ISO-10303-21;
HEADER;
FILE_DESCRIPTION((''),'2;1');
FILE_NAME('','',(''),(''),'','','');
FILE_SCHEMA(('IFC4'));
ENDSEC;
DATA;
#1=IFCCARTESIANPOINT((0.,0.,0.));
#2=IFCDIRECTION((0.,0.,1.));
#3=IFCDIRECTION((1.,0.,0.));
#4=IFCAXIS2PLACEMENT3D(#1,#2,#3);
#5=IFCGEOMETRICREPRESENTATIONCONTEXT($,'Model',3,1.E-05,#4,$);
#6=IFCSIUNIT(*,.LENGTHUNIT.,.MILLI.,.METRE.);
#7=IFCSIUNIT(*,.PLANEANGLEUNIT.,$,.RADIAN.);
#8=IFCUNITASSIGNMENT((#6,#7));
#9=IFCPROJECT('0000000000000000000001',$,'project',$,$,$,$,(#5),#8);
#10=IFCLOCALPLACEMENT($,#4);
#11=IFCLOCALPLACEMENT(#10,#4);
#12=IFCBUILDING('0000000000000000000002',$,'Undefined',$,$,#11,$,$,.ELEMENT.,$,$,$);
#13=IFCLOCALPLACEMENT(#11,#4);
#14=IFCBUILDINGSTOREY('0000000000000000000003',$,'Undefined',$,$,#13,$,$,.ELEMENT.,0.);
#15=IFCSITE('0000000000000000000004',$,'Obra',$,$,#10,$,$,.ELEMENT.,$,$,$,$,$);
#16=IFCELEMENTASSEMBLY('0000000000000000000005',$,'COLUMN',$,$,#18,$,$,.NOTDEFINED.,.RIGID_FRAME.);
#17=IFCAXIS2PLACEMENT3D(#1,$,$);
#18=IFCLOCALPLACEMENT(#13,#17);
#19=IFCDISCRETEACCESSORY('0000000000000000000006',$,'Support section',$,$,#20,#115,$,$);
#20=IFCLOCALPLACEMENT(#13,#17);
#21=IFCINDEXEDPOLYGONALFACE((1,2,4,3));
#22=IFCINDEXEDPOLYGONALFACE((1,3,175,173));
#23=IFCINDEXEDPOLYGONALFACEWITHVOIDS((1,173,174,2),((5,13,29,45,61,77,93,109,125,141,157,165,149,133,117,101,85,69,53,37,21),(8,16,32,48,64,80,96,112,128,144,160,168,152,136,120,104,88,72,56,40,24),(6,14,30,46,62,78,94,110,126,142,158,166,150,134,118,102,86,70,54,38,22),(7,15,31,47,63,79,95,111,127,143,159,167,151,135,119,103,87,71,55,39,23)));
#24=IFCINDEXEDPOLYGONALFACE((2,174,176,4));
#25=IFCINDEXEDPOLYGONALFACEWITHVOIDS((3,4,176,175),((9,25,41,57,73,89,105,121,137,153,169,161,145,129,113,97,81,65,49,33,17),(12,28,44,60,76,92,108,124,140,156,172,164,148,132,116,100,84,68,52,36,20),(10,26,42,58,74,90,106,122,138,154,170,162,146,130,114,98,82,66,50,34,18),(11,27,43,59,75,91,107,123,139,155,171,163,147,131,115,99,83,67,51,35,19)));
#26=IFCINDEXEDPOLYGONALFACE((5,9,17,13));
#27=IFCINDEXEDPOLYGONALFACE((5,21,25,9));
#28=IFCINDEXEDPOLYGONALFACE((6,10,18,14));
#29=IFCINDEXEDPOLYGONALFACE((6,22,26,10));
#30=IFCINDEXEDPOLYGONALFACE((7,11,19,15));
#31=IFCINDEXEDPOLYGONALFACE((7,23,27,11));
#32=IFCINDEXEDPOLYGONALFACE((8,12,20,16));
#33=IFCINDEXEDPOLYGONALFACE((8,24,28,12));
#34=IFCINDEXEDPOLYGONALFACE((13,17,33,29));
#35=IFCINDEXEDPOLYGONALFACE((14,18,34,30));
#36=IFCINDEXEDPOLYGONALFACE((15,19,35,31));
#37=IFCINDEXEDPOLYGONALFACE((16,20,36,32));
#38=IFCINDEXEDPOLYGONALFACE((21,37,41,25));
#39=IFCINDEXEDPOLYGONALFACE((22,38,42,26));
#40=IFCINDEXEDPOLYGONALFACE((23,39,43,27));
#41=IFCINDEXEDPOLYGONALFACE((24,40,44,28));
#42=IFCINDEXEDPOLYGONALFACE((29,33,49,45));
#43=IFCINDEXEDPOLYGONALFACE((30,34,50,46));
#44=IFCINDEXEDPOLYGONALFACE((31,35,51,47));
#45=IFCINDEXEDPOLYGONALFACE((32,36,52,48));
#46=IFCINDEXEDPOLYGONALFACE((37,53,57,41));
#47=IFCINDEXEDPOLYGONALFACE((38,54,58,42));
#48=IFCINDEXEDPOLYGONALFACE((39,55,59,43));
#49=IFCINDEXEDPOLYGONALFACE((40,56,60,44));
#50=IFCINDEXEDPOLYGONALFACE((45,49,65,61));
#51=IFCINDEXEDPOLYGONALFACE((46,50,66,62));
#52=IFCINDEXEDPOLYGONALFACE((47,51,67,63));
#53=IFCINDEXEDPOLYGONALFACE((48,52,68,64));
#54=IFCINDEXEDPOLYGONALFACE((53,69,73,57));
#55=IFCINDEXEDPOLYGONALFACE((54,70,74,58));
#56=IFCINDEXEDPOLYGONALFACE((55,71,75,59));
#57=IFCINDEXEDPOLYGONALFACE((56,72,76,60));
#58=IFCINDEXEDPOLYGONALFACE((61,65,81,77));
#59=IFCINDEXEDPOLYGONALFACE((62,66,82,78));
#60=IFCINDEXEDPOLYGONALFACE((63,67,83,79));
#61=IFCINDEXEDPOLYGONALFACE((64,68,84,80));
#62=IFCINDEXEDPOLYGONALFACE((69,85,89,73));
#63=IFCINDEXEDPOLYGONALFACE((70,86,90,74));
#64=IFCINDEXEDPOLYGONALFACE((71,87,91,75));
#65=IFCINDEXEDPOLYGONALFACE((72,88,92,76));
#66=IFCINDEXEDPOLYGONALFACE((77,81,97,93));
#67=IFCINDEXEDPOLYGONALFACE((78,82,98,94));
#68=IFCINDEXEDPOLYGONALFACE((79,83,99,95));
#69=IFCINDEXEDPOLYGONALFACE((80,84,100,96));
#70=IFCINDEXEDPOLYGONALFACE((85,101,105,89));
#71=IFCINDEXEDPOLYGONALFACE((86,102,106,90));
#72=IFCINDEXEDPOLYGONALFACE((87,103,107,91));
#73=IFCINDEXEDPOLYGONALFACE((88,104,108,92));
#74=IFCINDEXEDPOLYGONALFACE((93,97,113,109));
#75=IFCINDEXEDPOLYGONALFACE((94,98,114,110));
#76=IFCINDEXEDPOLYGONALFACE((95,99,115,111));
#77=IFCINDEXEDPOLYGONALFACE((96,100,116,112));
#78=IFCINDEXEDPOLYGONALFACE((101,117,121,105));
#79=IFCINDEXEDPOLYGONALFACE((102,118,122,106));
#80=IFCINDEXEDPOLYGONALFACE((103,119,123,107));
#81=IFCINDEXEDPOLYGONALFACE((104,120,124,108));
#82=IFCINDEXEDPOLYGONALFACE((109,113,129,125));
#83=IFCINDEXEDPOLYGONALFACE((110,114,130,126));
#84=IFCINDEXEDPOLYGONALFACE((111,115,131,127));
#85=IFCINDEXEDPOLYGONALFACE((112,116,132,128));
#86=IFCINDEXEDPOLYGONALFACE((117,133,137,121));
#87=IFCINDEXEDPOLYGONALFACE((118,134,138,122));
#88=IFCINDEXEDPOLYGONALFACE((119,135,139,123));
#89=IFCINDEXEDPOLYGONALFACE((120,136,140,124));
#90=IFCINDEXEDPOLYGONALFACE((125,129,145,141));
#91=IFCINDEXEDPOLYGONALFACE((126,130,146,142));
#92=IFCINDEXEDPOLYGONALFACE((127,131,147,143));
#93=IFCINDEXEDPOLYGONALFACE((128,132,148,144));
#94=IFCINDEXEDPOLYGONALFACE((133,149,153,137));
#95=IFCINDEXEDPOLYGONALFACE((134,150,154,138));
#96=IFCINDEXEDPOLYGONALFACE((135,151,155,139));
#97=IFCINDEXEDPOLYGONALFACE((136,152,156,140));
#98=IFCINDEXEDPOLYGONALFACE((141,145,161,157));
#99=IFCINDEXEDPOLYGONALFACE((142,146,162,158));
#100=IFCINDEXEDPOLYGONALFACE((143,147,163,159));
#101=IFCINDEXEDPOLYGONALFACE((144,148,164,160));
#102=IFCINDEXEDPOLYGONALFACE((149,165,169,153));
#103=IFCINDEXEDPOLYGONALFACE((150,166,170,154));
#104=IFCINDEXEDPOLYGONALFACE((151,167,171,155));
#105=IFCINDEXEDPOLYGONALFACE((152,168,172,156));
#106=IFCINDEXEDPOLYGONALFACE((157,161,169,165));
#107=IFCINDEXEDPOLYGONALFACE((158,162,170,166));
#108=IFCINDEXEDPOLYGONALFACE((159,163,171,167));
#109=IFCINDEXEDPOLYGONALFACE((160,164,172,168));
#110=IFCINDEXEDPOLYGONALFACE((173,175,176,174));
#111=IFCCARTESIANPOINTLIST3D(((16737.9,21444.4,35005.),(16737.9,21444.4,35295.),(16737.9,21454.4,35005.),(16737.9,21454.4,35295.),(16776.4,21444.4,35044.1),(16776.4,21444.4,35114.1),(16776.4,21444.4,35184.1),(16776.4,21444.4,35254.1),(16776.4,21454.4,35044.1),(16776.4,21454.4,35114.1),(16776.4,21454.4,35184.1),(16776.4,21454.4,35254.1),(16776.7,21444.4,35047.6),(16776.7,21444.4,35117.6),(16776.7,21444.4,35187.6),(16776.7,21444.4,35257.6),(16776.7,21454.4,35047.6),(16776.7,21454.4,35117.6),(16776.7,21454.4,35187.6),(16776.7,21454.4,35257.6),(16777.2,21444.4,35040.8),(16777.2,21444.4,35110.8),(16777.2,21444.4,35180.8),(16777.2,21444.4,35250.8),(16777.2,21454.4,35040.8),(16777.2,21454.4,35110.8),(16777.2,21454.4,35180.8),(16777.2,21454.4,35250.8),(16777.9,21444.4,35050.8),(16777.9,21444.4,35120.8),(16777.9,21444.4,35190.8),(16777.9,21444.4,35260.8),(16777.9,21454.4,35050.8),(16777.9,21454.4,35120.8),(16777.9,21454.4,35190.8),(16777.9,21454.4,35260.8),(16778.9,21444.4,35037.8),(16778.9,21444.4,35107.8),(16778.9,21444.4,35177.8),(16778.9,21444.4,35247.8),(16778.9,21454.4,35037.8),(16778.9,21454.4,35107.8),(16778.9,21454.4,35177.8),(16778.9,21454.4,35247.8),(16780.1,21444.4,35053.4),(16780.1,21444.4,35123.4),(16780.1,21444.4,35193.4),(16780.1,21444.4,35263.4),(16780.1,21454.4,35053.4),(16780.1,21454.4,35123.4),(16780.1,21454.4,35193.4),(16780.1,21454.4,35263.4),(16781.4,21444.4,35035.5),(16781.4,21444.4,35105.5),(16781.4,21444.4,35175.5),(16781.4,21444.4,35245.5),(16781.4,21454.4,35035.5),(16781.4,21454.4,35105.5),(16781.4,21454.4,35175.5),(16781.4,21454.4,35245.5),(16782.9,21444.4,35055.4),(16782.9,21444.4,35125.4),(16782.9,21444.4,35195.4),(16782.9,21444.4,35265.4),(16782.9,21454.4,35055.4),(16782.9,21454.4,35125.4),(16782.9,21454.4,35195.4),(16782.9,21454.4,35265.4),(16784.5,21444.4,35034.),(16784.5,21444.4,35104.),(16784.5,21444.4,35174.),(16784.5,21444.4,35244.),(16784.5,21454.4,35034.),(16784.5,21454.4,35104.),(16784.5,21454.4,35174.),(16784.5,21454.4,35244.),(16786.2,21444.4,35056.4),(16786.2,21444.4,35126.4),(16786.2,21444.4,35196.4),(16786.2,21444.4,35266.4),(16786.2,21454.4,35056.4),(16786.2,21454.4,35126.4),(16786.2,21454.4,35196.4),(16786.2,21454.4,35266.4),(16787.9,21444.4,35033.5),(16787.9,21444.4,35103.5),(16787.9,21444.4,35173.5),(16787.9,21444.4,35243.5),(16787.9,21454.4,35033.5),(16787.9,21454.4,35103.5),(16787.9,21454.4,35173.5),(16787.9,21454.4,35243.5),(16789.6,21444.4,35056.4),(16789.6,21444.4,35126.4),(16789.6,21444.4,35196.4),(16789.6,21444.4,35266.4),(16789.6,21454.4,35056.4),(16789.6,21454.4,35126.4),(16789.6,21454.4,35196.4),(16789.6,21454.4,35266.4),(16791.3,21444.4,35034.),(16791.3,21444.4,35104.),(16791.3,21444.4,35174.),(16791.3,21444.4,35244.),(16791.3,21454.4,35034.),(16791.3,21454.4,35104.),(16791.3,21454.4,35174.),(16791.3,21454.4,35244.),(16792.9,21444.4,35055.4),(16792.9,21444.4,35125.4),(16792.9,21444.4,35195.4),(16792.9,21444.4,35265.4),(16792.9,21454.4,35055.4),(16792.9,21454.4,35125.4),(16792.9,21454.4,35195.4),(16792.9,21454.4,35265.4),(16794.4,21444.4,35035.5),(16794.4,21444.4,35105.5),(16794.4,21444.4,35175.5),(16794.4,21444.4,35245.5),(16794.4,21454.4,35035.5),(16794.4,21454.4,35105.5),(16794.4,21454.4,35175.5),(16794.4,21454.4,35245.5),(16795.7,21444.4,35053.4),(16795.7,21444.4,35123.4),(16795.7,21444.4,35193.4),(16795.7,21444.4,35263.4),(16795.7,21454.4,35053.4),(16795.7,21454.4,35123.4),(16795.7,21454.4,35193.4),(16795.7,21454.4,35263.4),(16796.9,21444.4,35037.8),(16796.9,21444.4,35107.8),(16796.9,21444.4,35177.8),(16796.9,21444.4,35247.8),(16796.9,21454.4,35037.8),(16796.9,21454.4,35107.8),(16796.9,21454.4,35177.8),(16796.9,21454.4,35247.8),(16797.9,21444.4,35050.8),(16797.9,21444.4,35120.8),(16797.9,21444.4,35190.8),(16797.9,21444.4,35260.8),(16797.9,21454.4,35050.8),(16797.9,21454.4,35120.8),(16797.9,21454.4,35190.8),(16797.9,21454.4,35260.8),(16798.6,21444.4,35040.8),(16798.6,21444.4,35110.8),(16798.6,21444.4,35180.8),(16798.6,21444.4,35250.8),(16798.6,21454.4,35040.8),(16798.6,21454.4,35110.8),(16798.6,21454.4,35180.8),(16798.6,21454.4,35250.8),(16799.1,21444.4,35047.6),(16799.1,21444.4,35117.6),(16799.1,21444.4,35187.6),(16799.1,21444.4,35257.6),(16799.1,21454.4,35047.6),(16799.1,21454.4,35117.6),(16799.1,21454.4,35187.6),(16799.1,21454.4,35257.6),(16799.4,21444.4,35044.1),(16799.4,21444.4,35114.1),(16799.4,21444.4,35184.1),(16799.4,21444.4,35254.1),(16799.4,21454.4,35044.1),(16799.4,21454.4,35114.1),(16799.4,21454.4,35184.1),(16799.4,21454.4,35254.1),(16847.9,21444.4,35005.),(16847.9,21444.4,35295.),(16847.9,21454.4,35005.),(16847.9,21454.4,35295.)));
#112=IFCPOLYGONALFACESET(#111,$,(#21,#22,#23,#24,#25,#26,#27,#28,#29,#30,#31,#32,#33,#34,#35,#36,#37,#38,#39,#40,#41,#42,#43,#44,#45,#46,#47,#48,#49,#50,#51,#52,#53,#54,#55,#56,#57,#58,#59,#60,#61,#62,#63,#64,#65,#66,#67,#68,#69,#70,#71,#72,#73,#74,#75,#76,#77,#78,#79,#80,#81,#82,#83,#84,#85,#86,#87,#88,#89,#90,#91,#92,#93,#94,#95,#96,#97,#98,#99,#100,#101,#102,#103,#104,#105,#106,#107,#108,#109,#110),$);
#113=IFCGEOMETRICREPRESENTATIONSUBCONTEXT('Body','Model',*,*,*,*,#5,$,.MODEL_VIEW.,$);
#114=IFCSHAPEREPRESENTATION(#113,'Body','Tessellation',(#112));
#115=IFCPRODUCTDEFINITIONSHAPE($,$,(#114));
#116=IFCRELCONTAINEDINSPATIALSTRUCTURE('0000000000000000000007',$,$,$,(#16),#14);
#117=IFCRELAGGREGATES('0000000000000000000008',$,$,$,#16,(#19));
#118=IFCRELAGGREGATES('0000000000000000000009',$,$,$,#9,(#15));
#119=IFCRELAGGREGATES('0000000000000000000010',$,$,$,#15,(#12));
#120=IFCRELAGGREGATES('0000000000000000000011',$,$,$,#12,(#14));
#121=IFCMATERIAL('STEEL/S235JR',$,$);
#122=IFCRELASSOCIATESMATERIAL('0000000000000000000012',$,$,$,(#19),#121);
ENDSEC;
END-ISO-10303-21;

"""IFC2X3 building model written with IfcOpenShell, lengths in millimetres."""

from ifc_helpers import new_model, si_unit, frame, origin_with_axes, origin_2d_with_axis, place, context, subcontext, project, spatial, rectangle, circle, extrude, source, transform, mapped, material, element, aggregate, save


model = new_model("IFC2X3")

# Units and contexts
model_context = context("Model", 3, precision=1e-05, world=origin_with_axes())
body_context = subcontext(model_context, "Body", "Model", "MODEL_VIEW")
ifc_project = project(units=[si_unit("LENGTHUNIT", "METRE", prefix="MILLI"), si_unit("PLANEANGLEUNIT", "RADIAN")], contexts=[model_context])

# Site, building, storey
site_placement = place(None, origin_with_axes())
site = spatial("IfcSite", under=ifc_project, at=site_placement, Name="Obra", CompositionType="ELEMENT")
building_placement = place(site_placement, origin_with_axes())
building = spatial("IfcBuilding", under=site, at=building_placement, Name="Undefined", CompositionType="ELEMENT")
storey_placement = place(building_placement, origin_with_axes())
storey = spatial("IfcBuildingStorey", under=building, at=storey_placement, Name="Undefined", CompositionType="ELEMENT", Elevation=0.0)

# Element assembly
assembly_1_placement = place(storey_placement, origin_with_axes())
assembly_1 = element("IfcElementAssembly", 1, at=assembly_1_placement, inside=storey, Name="COLUMN", AssemblyPlace="NOTDEFINED", PredefinedType="RIGID_FRAME")
ifc_material_1 = material(Name="STEEL/S235JR")

# Discrete accessory, opening
discrete_accessory_1_placement = place(assembly_1_placement, frame((16792.9, 21449.4, 35005.0), z_axis=(0.0, 0.0, 1.0), x_axis=(1.0, 0.0, 0.0)))
discrete_accessory_1 = element("IfcDiscreteAccessory", 2, at=discrete_accessory_1_placement, material=ifc_material_1, Name="Support section", context=body_context, shape_type="SweptSolid", body=[
    extrude(rectangle(XDim=10.0, YDim=110.0, at=origin_2d_with_axis()), frame((0.0, 0.0, 290.0), z_axis=(0.0, 0.0, -1.0), x_axis=(0.0, 1.0, 0.0)), (0.0, 0.0, 1.0), 290.0),
])
shared_shape_1 = source(origin_with_axes(), body_context, "Body", "SweptSolid", [
    extrude(circle(Radius=11.5, at=origin_2d_with_axis()), frame((0.0, -14.4, 0.0), z_axis=(0.0, 1.0, 0.0), x_axis=(1.0, 0.0, 0.0)), (0.0, 0.0, 1.0), 10.2),
])
opening_1_placement = place(assembly_1_placement, frame((16837.9, 21440.1, 35350.0), z_axis=(-1.0, 0.0, 0.0), x_axis=(0.0, 0.0, -1.0)))
element("IfcOpeningElement", 3, at=opening_1_placement, cuts=discrete_accessory_1, ObjectType="Opening", context=body_context, shape_type="MappedRepresentation", body=[
    mapped(shared_shape_1, transform((95.0, 0.0, 50.0))),
    mapped(shared_shape_1, transform((165.0, 0.0, 50.0))),
    mapped(shared_shape_1, transform((235.0, 0.0, 50.0))),
    mapped(shared_shape_1, transform((305.0, 0.0, 50.0))),
])

aggregate(assembly_1, [discrete_accessory_1])

save(model, "model.ifc")
